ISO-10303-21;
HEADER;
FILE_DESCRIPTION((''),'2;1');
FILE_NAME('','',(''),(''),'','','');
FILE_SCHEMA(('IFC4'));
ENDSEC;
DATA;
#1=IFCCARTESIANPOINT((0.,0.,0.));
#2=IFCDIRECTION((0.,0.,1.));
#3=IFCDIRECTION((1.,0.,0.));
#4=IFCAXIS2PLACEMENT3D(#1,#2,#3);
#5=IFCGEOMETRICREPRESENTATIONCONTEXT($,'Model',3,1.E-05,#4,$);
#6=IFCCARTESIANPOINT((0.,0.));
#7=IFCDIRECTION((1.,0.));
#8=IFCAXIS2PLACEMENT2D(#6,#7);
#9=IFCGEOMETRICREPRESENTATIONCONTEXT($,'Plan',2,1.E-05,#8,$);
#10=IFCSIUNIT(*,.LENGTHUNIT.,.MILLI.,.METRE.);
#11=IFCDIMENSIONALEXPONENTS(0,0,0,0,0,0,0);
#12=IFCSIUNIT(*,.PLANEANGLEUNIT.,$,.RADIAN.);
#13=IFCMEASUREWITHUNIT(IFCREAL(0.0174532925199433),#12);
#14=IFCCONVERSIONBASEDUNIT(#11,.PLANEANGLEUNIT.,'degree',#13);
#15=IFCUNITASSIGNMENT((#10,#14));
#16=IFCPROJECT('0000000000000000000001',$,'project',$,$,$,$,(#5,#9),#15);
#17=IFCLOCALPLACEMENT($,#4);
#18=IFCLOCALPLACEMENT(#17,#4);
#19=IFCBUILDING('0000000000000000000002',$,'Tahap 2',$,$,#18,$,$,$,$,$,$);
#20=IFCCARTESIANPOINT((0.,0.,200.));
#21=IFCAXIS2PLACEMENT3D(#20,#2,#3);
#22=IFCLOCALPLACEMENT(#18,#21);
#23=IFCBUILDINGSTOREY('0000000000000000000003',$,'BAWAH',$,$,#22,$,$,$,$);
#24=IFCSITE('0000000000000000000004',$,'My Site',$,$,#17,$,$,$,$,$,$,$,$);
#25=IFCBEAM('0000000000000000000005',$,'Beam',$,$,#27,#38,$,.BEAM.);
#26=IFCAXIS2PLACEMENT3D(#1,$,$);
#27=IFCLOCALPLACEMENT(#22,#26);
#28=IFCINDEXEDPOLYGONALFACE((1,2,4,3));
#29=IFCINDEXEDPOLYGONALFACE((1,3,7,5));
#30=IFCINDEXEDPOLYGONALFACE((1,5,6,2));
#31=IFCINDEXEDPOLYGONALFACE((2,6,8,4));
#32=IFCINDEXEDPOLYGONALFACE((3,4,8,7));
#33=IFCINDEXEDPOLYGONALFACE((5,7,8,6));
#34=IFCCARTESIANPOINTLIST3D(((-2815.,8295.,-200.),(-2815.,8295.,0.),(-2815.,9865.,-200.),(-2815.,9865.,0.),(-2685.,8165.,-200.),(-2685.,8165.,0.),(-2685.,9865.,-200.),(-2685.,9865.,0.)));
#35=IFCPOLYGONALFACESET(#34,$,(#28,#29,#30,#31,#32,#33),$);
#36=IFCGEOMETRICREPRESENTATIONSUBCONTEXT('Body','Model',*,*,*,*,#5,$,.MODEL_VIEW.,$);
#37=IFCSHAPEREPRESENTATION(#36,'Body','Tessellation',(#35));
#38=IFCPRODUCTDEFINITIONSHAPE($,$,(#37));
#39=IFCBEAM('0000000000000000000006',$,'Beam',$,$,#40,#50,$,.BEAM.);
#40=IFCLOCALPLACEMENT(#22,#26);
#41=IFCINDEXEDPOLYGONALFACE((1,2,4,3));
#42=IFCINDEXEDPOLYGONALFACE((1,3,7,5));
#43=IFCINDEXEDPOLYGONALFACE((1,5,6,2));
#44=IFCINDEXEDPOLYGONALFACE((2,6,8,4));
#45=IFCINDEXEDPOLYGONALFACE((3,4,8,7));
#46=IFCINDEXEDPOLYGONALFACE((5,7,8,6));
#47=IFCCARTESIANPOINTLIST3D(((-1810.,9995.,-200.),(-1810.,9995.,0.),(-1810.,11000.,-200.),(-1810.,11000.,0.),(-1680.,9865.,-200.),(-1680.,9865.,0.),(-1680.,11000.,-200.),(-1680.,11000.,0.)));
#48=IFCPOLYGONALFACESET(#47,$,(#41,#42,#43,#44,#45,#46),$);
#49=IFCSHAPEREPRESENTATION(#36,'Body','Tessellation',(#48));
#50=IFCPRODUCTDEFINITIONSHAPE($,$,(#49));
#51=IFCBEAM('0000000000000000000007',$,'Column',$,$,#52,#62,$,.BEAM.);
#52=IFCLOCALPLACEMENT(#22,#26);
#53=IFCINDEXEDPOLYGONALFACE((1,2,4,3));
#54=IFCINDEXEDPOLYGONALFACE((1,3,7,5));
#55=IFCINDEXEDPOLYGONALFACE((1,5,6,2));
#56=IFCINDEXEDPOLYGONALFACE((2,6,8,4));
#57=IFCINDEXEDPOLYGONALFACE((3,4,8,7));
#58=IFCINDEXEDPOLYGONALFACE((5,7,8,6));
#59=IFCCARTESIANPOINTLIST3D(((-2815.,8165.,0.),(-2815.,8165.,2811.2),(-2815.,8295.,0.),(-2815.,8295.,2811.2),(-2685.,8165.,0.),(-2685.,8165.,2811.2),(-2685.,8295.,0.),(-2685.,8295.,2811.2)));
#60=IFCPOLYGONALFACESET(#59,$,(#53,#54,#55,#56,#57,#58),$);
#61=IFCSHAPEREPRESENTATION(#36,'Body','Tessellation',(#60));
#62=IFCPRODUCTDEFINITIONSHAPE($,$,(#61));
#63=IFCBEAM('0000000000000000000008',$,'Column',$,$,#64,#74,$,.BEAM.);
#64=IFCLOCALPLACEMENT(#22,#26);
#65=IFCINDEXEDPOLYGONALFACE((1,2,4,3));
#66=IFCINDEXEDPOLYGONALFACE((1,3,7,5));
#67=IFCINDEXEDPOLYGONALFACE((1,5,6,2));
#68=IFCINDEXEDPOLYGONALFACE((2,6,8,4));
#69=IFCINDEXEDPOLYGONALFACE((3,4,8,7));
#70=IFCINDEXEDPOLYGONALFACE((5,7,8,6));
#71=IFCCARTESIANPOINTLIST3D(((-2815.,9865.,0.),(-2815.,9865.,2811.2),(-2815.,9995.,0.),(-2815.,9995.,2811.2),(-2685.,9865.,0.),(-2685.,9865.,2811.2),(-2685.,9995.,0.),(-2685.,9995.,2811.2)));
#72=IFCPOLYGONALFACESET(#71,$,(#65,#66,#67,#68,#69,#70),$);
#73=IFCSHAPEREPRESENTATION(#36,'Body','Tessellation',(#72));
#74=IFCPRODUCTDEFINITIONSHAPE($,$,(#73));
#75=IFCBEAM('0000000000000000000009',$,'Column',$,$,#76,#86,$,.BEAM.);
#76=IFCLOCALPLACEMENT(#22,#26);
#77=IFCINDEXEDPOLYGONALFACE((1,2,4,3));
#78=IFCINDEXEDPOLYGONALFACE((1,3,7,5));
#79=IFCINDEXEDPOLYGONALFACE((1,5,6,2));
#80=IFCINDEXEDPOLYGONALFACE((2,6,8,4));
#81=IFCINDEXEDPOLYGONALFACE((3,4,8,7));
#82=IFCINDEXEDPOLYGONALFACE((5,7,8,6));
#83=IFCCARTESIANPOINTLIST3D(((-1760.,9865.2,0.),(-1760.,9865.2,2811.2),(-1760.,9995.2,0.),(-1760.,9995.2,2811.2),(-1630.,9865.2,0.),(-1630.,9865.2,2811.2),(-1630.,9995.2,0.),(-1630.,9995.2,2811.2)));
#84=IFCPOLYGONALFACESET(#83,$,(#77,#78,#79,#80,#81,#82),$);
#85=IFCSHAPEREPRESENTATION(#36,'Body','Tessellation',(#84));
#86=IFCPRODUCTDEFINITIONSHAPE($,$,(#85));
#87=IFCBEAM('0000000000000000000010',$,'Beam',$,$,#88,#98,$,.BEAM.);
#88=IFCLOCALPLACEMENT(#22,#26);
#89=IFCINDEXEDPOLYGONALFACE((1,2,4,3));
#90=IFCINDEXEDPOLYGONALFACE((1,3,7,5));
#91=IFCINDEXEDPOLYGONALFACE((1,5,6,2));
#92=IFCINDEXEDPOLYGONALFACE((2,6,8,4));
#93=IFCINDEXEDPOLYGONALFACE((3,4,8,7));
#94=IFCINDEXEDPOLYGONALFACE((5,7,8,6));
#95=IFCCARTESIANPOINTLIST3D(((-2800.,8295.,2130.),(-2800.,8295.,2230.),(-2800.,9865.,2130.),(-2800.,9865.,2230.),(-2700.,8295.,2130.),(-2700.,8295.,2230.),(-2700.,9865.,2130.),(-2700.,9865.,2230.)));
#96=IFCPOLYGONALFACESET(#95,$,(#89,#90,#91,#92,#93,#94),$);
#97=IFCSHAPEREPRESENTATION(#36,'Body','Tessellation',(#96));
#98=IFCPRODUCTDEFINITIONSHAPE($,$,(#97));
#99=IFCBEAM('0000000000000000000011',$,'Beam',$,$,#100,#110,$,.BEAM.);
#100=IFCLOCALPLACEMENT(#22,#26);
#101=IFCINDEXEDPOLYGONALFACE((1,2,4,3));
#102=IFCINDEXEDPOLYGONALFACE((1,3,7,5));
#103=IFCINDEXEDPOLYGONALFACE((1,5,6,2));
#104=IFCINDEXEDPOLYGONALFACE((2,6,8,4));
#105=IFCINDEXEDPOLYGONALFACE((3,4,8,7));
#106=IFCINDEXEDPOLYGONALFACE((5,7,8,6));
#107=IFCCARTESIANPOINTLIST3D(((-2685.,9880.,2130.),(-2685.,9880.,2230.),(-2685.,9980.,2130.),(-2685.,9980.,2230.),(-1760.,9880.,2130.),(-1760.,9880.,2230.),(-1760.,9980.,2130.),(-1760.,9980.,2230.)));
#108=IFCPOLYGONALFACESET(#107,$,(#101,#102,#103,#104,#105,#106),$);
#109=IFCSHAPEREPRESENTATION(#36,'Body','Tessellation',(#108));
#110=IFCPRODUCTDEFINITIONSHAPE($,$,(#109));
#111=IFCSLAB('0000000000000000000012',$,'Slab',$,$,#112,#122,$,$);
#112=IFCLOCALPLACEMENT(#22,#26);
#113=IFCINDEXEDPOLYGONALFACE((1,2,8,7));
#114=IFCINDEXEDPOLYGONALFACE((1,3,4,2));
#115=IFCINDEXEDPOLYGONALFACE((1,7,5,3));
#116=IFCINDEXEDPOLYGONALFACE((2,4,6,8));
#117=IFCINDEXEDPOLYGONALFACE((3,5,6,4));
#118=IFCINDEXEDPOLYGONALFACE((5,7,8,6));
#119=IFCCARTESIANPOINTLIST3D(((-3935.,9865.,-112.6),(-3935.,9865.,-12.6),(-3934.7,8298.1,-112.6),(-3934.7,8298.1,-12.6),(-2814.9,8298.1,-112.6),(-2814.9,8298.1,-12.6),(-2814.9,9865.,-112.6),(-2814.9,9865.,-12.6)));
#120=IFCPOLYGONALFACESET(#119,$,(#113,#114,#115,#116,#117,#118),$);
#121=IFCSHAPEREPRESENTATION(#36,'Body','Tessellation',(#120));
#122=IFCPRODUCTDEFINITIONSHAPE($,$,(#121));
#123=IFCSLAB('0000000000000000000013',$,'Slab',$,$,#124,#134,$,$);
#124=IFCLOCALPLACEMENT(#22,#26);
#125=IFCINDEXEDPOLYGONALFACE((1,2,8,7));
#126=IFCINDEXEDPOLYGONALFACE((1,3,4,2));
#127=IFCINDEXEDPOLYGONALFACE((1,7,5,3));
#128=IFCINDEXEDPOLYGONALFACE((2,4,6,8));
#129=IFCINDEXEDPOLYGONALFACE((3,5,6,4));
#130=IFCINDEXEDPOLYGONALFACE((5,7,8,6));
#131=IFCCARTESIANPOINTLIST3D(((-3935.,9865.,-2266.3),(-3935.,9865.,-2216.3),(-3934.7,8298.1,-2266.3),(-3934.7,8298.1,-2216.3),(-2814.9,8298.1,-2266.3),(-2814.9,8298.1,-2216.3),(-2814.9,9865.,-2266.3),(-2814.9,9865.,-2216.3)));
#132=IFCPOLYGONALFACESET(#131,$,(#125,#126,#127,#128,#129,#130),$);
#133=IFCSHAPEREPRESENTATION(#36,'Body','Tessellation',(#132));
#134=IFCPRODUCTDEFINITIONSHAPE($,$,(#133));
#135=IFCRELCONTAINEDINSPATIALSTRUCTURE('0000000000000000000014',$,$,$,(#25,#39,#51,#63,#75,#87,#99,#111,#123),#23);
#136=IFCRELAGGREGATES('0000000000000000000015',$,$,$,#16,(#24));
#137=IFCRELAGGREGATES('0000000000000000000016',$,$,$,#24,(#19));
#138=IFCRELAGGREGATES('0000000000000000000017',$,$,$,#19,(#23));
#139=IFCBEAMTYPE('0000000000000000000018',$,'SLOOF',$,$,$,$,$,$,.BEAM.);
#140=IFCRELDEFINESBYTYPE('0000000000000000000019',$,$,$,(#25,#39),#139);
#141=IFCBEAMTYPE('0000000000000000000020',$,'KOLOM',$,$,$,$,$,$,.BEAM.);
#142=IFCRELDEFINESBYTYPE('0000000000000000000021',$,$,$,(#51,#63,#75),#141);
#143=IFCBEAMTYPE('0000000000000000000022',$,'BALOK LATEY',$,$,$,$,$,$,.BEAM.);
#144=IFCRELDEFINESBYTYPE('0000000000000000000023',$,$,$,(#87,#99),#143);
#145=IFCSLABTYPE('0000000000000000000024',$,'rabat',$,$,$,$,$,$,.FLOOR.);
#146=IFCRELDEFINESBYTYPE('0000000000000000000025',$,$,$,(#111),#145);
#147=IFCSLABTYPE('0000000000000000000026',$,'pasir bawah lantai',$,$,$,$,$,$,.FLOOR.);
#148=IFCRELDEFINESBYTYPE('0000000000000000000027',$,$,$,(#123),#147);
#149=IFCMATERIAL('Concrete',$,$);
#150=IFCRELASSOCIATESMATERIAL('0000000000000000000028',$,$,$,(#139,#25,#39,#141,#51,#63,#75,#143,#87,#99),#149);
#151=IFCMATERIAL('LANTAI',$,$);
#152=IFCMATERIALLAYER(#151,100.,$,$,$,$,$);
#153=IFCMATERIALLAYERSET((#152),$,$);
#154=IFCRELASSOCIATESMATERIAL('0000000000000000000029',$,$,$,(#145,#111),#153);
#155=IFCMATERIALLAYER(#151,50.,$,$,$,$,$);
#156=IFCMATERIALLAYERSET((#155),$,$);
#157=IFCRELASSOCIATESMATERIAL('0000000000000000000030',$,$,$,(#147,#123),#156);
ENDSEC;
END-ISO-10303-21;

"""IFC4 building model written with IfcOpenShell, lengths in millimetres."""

from ifc_helpers import new_model, entity, si_unit, converted_unit, frame, origin_with_axes, origin_2d_with_axis, place, context, subcontext, project, spatial, indexed_curve, rectangle, outline, extrude, clip, halfspace, material, layer, layer_set, layer_usage, material_profile, profile_set, profile_usage, type_object, element, save


model = new_model("IFC4")

# Units and contexts
model_context = context("Model", 3, precision=1e-05, world=origin_with_axes())
plan_context = context("Plan", 2, precision=1e-05, world=origin_2d_with_axis())
body_context_1 = subcontext(model_context, "Body", "Model", "MODEL_VIEW")
ifc_project = project(units=[si_unit("LENGTHUNIT", "METRE", prefix="MILLI"), converted_unit("PLANEANGLEUNIT", "degree", entity("IfcReal", 0.0174532925199433), si_unit("PLANEANGLEUNIT", "RADIAN"), dimensions=[0, 0, 0, 0, 0, 0, 0])], contexts=[model_context, plan_context])

# Site, building, storey
site_placement = place(None, origin_with_axes())
site = spatial("IfcSite", under=ifc_project, at=site_placement, Name="My Site")
building_placement = place(site_placement, origin_with_axes())
building = spatial("IfcBuilding", under=site, at=building_placement, Name="Tahap 2")
storey_placement = place(building_placement, frame((0.0, 0.0, 200.0), z_axis=(0.0, 0.0, 1.0), x_axis=(1.0, 0.0, 0.0)))
storey = spatial("IfcBuildingStorey", under=building, at=storey_placement, Name="BAWAH")

# Beams
ifc_material_1 = material(Name="Concrete")
ifc_material_profile_1 = material_profile(ifc_material_1, outline(indexed_curve([(-65.0, 100.0), (65.0, 100.0), (65.0, -100.0), (-65.0, -100.0), (-65.0, 100.0)])))
ifc_profile_set_1 = profile_set([ifc_material_profile_1])
ifc_profile_usage_1 = profile_usage(ifc_profile_set_1, cardinal=2)
beam_type_1 = type_object("IfcBeamType", Name="SLOOF", PredefinedType="BEAM", material=ifc_profile_set_1)
beam_1_placement = place(storey_placement, frame((-2750.0, 8165.0, -200.0), z_axis=(0.0, 1.0, 0.0), x_axis=(-1.0, 0.0, 0.0)))
element("IfcBeam", 1, at=beam_1_placement, inside=storey, type_object=beam_type_1, material=ifc_profile_usage_1, Name="Beam", PredefinedType="BEAM", context=body_context_1, shape_type="Clipping", body=[
    clip(extrude(outline(indexed_curve([(-65.0, 100.0), (65.0, 100.0), (65.0, -100.0), (-65.0, -100.0), (-65.0, 100.0)])), frame((0.0, 100.0, 0.0), z_axis=(0.0, 0.0, 1.0), x_axis=(1.0, 0.0, 0.0)), (0.0, 0.0, 1.0), 1700.0), halfspace(frame((-65.0, 0.0, 0.0), z_axis=(0.707104, 0.0, -0.707109), x_axis=(0.0, -1.0, 0.0)), False)),
])
ifc_profile_usage_2 = profile_usage(ifc_profile_set_1, cardinal=2)
beam_2_placement = place(storey_placement, frame((-1745.0, 9865.0, -200.0), z_axis=(0.0, 1.0, 0.0), x_axis=(-1.0, 0.0, 0.0)))
element("IfcBeam", 2, at=beam_2_placement, inside=storey, type_object=beam_type_1, material=ifc_profile_usage_2, Name="Beam", PredefinedType="BEAM", context=body_context_1, shape_type="Clipping", body=[
    clip(extrude(outline(indexed_curve([(-65.0, 100.0), (65.0, 100.0), (65.0, -100.0), (-65.0, -100.0), (-65.0, 100.0)])), frame((0.0, 100.0, 0.0), z_axis=(0.0, 0.0, 1.0), x_axis=(1.0, 0.0, 0.0)), (0.0, 0.0, 1.0), 1135.0), halfspace(frame((-65.0, 0.0, 0.0), z_axis=(0.707104, 0.0, -0.707109), x_axis=(0.0, -1.0, 0.0)), False)),
])
ifc_material_profile_2 = material_profile(ifc_material_1, rectangle(XDim=130.0, YDim=130.0, kind="CURVE"))
ifc_profile_set_2 = profile_set([ifc_material_profile_2])
ifc_profile_usage_3 = profile_usage(ifc_profile_set_2, cardinal=5)
beam_type_2 = type_object("IfcBeamType", Name="KOLOM", PredefinedType="BEAM", material=ifc_profile_set_2)
beam_3_placement = place(storey_placement, frame((-2750.0, 8230.0, 0.0), z_axis=(0.0, 0.0, 1.0), x_axis=(1.0, 0.0, 0.0)))
element("IfcBeam", 3, at=beam_3_placement, inside=storey, type_object=beam_type_2, material=ifc_profile_usage_3, Name="Column", PredefinedType="BEAM", context=body_context_1, shape_type="SweptSolid", body=[
    extrude(rectangle(XDim=130.0, YDim=130.0, kind="CURVE"), origin_with_axes(), (0.0, 0.0, 1.0), 2811.2),
])
ifc_profile_usage_4 = profile_usage(ifc_profile_set_2, cardinal=5)
beam_4_placement = place(storey_placement, frame((-2750.0, 9930.0, 0.0), z_axis=(0.0, 0.0, 1.0), x_axis=(1.0, 0.0, 0.0)))
element("IfcBeam", 4, at=beam_4_placement, inside=storey, type_object=beam_type_2, material=ifc_profile_usage_4, Name="Column", PredefinedType="BEAM", context=body_context_1, shape_type="SweptSolid", body=[
    extrude(rectangle(XDim=130.0, YDim=130.0, kind="CURVE"), origin_with_axes(), (0.0, 0.0, 1.0), 2811.2),
])
ifc_profile_usage_5 = profile_usage(ifc_profile_set_2, cardinal=5)
beam_5_placement = place(storey_placement, frame((-1695.0, 9930.2, 0.0), z_axis=(0.0, 0.0, 1.0), x_axis=(1.0, 0.0, 0.0)))
element("IfcBeam", 5, at=beam_5_placement, inside=storey, type_object=beam_type_2, material=ifc_profile_usage_5, Name="Column", PredefinedType="BEAM", context=body_context_1, shape_type="SweptSolid", body=[
    extrude(rectangle(XDim=130.0, YDim=130.0, kind="CURVE"), origin_with_axes(), (0.0, 0.0, 1.0), 2811.2),
])

# Beams
ifc_material_profile_3 = material_profile(ifc_material_1, rectangle(XDim=100.0, YDim=100.0))
ifc_profile_set_3 = profile_set([ifc_material_profile_3])
ifc_profile_usage_6 = profile_usage(ifc_profile_set_3)
beam_type_3 = type_object("IfcBeamType", Name="BALOK LATEY", PredefinedType="BEAM", material=ifc_profile_set_3)
beam_6_placement = place(storey_placement, frame((-2750.0, 8295.0, 2180.0), z_axis=(0.0, 1.0, 0.0), x_axis=(-1.0, 0.0, 0.0)))
element("IfcBeam", 6, at=beam_6_placement, inside=storey, type_object=beam_type_3, material=ifc_profile_usage_6, Name="Beam", PredefinedType="BEAM", context=body_context_1, shape_type="SweptSolid", body=[
    extrude(rectangle(XDim=100.0, YDim=100.0), origin_with_axes(), (0.0, 0.0, 1.0), 1570.0),
])
ifc_profile_usage_7 = profile_usage(ifc_profile_set_3)
beam_7_placement = place(storey_placement, frame((-2685.0, 9930.0, 2180.0), z_axis=(1.0, 0.000001, 0.0), x_axis=(-0.000001, 1.0, 0.0)))
element("IfcBeam", 7, at=beam_7_placement, inside=storey, type_object=beam_type_3, material=ifc_profile_usage_7, Name="Beam", PredefinedType="BEAM", context=body_context_1, shape_type="SweptSolid", body=[
    extrude(rectangle(XDim=100.0, YDim=100.0), origin_with_axes(), (0.0, 0.0, 1.0), 925.0),
])

# Slabs
ifc_material_2 = material(Name="LANTAI")
ifc_layer_1 = layer(ifc_material_2, 100.0)
ifc_layer_set_1 = layer_set([ifc_layer_1])
ifc_layer_usage_1 = layer_usage(ifc_layer_set_1, "AXIS3", "NEGATIVE", 0.0)
slab_type_1 = type_object("IfcSlabType", Name="rabat", PredefinedType="FLOOR", material=ifc_layer_set_1)
slab_1_placement = place(storey_placement, frame((-3934.7, 8298.1, -12.6), z_axis=(0.0, 0.0, 1.0), x_axis=(1.0, 0.0, 0.0)))
element("IfcSlab", 8, at=slab_1_placement, inside=storey, type_object=slab_type_1, material=ifc_layer_usage_1, Name="Slab", context=body_context_1, shape_type="SweptSolid", body=[
    extrude(outline(indexed_curve([(0.0, 0.0), (1119.7, 0.0), (1119.7, 1566.9), (-0.3, 1566.9), (0.0, 0.0)])), None, (0.0, 0.0, -1.0), 100.0),
])
ifc_layer_2 = layer(ifc_material_2, 50.0)
ifc_layer_set_2 = layer_set([ifc_layer_2])
ifc_layer_usage_2 = layer_usage(ifc_layer_set_2, "AXIS3", "POSITIVE", -50.0)
slab_type_2 = type_object("IfcSlabType", Name="pasir bawah lantai", PredefinedType="FLOOR", material=ifc_layer_set_2)
slab_2_placement = place(storey_placement, frame((-3934.7, 8298.1, -2216.3), z_axis=(0.0, 0.0, 1.0), x_axis=(1.0, 0.0, 0.0)))
element("IfcSlab", 9, at=slab_2_placement, inside=storey, type_object=slab_type_2, material=ifc_layer_usage_2, Name="Slab", context=body_context_1, shape_type="SweptSolid", body=[
    extrude(outline(indexed_curve([(0.0, 0.0), (1119.7, 0.0), (1119.7, 1566.9), (-0.3, 1566.9), (0.0, 0.0)])), frame((0.0, 0.0, -50.0), z_axis=(0.0, 0.0, 1.0), x_axis=(1.0, 0.0, 0.0)), (0.0, 0.0, 1.0), 50.0),
])

save(model, "model.ifc")
